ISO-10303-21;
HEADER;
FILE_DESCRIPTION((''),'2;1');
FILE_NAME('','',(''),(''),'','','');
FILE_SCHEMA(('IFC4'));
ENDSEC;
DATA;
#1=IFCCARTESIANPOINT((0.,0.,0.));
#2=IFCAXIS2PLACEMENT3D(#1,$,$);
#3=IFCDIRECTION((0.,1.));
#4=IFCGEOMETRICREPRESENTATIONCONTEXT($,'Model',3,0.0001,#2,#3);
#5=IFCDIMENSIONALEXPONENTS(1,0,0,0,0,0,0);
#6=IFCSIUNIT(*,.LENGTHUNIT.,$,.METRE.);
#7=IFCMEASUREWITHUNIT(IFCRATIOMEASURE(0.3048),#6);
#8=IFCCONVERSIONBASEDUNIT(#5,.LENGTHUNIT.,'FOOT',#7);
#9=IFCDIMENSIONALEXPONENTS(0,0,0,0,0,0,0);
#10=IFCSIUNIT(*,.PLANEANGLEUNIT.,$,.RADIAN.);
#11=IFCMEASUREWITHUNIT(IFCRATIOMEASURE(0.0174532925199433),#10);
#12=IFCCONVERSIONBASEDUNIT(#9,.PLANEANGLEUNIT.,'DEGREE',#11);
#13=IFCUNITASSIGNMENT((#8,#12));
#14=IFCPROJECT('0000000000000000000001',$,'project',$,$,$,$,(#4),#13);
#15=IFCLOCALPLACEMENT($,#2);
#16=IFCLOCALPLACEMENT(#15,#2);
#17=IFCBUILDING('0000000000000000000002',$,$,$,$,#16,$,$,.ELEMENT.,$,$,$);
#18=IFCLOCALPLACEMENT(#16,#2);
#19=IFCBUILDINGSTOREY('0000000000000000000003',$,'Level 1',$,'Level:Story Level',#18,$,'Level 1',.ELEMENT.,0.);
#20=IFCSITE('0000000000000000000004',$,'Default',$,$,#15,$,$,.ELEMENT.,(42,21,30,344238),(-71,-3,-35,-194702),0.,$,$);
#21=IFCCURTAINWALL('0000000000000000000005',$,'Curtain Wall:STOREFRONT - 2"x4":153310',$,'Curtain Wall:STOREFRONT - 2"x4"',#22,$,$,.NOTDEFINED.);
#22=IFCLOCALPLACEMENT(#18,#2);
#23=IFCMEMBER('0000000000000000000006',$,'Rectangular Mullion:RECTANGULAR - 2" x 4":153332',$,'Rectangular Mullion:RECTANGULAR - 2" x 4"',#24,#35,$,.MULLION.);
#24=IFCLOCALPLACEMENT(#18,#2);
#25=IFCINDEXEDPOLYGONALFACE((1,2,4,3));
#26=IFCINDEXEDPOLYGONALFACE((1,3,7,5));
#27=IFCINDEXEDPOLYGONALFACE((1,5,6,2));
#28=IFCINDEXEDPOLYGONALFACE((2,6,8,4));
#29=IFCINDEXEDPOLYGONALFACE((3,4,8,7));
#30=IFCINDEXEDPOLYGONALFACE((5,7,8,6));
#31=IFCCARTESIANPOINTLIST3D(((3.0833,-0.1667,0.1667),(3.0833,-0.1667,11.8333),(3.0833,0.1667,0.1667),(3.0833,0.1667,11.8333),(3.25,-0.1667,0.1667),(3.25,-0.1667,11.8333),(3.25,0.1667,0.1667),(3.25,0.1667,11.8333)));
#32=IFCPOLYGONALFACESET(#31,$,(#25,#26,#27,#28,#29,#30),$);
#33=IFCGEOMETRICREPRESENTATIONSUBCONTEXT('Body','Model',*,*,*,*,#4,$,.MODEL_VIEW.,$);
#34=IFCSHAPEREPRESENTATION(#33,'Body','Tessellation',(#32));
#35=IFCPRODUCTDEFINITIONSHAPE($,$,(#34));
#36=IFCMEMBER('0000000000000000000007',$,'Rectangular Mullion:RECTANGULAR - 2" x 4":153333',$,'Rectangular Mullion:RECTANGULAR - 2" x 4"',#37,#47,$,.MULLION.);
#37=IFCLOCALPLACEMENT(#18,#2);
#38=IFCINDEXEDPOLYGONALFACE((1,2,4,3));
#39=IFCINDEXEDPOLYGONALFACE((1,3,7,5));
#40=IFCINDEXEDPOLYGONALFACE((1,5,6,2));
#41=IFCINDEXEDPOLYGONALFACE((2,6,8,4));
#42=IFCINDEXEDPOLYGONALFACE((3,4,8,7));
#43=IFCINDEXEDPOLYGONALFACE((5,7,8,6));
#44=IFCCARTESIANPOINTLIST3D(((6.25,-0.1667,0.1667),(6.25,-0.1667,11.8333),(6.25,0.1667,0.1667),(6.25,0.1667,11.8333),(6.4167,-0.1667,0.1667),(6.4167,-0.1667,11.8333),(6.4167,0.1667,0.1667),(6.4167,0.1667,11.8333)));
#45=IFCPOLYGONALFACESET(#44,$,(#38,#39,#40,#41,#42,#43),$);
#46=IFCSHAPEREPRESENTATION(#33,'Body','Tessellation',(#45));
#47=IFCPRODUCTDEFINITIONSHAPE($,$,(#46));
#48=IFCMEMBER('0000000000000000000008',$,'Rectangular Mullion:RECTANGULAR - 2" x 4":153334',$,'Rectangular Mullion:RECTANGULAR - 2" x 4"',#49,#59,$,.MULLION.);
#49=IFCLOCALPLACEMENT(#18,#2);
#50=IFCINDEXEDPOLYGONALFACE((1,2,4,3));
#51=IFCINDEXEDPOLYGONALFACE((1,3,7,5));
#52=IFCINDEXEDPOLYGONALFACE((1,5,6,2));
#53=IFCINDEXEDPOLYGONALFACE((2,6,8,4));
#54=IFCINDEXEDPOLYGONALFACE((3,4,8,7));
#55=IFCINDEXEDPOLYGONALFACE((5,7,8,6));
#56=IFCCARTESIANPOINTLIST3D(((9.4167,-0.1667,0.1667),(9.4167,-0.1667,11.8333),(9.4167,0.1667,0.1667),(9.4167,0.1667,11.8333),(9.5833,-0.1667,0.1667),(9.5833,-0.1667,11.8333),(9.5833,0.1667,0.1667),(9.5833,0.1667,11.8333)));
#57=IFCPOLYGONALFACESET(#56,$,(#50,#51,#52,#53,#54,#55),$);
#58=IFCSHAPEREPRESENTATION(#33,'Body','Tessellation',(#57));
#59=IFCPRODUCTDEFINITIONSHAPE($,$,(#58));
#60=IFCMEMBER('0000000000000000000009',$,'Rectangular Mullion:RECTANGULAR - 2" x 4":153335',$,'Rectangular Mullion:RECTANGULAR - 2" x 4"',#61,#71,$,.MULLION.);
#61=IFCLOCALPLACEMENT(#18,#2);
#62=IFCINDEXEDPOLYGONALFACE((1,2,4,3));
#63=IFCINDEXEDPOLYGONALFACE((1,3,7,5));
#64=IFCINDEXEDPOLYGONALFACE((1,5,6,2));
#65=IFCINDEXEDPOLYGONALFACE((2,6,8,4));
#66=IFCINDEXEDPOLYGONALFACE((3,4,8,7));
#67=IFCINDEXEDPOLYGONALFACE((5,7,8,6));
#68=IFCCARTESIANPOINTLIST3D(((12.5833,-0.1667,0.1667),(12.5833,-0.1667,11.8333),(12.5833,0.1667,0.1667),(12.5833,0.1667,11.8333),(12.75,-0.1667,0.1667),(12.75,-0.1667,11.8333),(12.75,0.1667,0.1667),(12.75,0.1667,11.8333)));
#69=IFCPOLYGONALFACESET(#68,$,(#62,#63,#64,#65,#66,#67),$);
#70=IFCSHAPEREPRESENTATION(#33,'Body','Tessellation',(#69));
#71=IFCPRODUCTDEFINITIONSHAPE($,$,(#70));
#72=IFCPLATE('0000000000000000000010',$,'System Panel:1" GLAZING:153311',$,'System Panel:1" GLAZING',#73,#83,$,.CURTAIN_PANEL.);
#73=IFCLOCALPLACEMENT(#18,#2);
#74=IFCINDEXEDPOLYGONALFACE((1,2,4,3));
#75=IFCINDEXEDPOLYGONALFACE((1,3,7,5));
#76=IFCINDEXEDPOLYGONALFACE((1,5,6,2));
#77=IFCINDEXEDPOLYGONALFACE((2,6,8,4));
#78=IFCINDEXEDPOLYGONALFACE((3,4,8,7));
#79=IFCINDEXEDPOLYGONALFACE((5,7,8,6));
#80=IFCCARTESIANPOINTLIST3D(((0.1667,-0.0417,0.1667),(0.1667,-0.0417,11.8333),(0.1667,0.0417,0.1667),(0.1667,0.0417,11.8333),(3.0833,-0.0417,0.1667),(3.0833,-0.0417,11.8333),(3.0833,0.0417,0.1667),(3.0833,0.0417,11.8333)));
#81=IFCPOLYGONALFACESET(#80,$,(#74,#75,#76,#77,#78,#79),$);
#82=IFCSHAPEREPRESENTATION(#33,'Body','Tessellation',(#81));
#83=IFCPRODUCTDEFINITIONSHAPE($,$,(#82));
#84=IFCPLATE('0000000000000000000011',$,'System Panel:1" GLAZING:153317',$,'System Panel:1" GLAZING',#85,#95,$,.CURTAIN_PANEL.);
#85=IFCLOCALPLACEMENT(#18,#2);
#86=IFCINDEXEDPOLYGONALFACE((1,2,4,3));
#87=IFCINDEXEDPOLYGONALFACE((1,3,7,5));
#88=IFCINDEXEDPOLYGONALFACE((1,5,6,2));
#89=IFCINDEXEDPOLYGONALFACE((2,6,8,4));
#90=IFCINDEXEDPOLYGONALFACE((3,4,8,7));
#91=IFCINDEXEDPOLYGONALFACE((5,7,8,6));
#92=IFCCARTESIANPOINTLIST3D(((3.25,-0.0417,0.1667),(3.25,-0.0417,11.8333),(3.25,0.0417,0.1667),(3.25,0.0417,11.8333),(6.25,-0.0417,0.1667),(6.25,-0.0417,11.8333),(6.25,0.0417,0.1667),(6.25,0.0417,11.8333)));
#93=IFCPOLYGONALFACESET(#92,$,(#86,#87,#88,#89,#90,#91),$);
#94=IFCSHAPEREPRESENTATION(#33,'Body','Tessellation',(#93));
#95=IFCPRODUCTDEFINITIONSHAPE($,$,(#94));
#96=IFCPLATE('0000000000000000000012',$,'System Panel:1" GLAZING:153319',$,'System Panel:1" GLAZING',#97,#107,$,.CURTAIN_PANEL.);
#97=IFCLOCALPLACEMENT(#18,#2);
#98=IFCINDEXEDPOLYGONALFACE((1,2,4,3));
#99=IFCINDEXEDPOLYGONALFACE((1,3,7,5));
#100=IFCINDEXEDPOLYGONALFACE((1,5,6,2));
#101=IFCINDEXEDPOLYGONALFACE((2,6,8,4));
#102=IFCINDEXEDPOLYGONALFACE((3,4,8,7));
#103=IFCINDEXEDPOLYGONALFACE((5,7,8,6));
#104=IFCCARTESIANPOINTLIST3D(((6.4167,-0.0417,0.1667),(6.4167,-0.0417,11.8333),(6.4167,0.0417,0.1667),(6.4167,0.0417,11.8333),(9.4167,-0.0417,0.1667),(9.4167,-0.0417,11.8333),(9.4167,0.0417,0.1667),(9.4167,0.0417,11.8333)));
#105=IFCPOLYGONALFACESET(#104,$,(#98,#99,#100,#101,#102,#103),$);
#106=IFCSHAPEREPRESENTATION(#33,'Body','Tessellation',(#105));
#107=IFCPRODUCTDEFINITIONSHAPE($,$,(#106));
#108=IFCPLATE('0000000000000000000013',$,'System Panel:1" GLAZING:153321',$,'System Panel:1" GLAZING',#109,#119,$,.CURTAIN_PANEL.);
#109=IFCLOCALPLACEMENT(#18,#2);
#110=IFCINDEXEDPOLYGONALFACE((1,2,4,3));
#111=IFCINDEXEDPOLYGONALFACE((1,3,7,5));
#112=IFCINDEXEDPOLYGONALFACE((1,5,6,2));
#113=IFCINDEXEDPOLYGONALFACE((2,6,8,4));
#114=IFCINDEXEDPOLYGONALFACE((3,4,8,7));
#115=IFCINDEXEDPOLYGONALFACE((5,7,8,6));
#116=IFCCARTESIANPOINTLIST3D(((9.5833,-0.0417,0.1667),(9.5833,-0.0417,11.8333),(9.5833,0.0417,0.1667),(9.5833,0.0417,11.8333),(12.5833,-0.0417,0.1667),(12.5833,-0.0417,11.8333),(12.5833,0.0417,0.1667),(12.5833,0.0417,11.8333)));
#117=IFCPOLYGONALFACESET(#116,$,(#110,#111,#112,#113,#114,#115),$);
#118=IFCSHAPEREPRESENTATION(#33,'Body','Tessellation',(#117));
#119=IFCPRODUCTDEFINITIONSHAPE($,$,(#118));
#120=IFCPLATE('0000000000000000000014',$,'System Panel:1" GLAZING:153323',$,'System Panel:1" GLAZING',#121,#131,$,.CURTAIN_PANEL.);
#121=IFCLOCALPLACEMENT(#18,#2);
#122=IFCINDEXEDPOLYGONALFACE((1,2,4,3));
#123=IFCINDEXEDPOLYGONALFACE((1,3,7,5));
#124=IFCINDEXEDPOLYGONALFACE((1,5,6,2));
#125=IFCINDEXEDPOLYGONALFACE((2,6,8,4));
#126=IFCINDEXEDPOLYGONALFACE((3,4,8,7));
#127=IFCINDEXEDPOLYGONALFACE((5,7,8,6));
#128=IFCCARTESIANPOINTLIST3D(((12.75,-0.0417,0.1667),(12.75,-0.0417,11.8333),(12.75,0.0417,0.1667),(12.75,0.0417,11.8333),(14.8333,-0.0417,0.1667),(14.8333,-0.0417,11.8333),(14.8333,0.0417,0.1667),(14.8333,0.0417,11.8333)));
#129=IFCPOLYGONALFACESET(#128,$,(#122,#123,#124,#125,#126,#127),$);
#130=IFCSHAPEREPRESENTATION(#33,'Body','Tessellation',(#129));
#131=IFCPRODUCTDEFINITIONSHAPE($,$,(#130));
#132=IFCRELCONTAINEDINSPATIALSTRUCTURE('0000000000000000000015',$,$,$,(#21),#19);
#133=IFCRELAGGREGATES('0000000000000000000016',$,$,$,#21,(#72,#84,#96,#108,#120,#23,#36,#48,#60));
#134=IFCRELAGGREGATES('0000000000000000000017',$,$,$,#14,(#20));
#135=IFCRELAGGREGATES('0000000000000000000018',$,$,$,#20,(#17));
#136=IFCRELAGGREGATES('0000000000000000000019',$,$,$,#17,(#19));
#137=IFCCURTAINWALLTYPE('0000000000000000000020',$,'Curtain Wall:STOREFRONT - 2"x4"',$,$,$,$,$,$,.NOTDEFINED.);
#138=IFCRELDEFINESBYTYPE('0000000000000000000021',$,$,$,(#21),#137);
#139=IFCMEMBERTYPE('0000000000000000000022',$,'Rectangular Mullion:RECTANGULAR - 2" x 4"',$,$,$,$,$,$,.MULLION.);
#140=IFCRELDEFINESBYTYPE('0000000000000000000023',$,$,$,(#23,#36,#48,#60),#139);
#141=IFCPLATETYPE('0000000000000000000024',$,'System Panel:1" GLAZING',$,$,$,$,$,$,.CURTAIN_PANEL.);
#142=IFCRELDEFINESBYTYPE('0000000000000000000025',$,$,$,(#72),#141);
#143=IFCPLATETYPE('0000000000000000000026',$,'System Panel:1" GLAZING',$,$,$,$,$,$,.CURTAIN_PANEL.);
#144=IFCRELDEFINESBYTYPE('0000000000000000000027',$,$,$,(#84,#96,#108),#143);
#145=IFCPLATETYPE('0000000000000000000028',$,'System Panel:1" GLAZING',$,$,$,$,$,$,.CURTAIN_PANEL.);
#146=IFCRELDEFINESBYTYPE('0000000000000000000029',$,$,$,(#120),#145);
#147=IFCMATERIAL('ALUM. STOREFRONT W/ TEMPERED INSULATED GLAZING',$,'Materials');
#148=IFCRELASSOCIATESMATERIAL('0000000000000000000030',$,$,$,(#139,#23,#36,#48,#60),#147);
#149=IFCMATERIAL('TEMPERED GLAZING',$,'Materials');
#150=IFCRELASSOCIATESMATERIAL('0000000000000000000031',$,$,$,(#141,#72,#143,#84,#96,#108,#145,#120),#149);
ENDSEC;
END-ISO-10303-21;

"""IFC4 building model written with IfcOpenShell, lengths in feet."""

from ifc_helpers import new_model, entity, si_unit, converted_unit, direction, frame, origin, origin_2d_with_axis, place, context, subcontext, project, spatial, rectangle, extrude, shape, source, transform, mapped, material, material_profile, profile_set, profile_usage, type_object, type_shapes, element, aggregate, save


model = new_model("IFC4")

# Units and contexts
model_context = context("Model", 3, precision=0.0001, world=origin(), true_north=direction((0.0, 1.0)))
body_context = subcontext(model_context, "Body", "Model", "MODEL_VIEW")
footprint_context = subcontext(model_context, "FootPrint", "Model", "MODEL_VIEW")
ifc_project = project(units=[converted_unit("LENGTHUNIT", "FOOT", entity("IfcRatioMeasure", 0.3048), si_unit("LENGTHUNIT", "METRE"), dimensions=[1, 0, 0, 0, 0, 0, 0]), converted_unit("PLANEANGLEUNIT", "DEGREE", entity("IfcRatioMeasure", 0.0174532925199433), si_unit("PLANEANGLEUNIT", "RADIAN"), dimensions=[0, 0, 0, 0, 0, 0, 0])], contexts=[model_context])

# Site, building, storey
site_placement = place(None, origin())
site = spatial("IfcSite", under=ifc_project, at=site_placement, Name="Default", CompositionType="ELEMENT", RefLatitude=(42, 21, 30, 344238), RefLongitude=(-71, -3, -35, -194702), RefElevation=0.0)
building_placement = place(site_placement, origin())
building = spatial("IfcBuilding", under=site, at=building_placement, CompositionType="ELEMENT")
storey_placement = place(building_placement, origin())
storey = spatial("IfcBuildingStorey", under=building, at=storey_placement, Name="Level 1", ObjectType="Level:Story Level", LongName="Level 1", CompositionType="ELEMENT", Elevation=0.0)

# Curtain wall, members, plates
curtain_wall_type = type_object("IfcCurtainWallType", Name="Curtain Wall:STOREFRONT - 2\"x4\"", PredefinedType="NOTDEFINED")
curtain_wall_placement = place(storey_placement, origin())
curtain_wall = element("IfcCurtainWall", 1, at=curtain_wall_placement, inside=storey, type_object=curtain_wall_type, Name="Curtain Wall:STOREFRONT - 2\"x4\":153310", ObjectType="Curtain Wall:STOREFRONT - 2\"x4\"", PredefinedType="NOTDEFINED")
ifc_material_1 = material(Name="ALUM. STOREFRONT W/ TEMPERED INSULATED GLAZING", Category="Materials")
ifc_material_profile = material_profile(ifc_material_1, rectangle(XDim=0.3333, YDim=0.1667, at=origin_2d_with_axis()), Name="RECTANGULAR - 2\" x 4\"")
ifc_profile_set = profile_set([ifc_material_profile], Name="RECTANGULAR - 2\" x 4\"")
ifc_profile_usage_1 = profile_usage(ifc_profile_set)
member_type_1 = type_object("IfcMemberType", Name="Rectangular Mullion:RECTANGULAR - 2\" x 4\"", PredefinedType="MULLION", material=ifc_profile_set)
shared_shape_1 = source(origin(), body_context, "Body", "SweptSolid", [
    extrude(rectangle(XDim=0.3333, YDim=0.1667, at=origin_2d_with_axis()), frame((0.0, 0.0, -11.6667), z_axis=(0.0, 0.0, 1.0), x_axis=(0.0, -1.0, 0.0)), (0.0, 0.0, 1.0), 11.6667),
])
type_shapes(member_type_1, [shared_shape_1])
member_1_placement = place(storey_placement, frame((3.1667, 0.0, 0.1667), z_axis=(0.0, 0.0, -1.0), x_axis=(1.0, 0.0, 0.0)))
member_1 = element("IfcMember", 2, at=member_1_placement, type_object=member_type_1, material=ifc_profile_usage_1, Name="Rectangular Mullion:RECTANGULAR - 2\" x 4\":153332", ObjectType="Rectangular Mullion:RECTANGULAR - 2\" x 4\"", PredefinedType="MULLION", context=body_context, shape_type="MappedRepresentation", body=[
    mapped(shared_shape_1, transform((0.0, 0.0, 0.0), scale=1.0)),
])
ifc_profile_usage_2 = profile_usage(ifc_profile_set)
member_2_placement = place(storey_placement, frame((6.3333, 0.0, 0.1667), z_axis=(0.0, 0.0, -1.0), x_axis=(1.0, 0.0, 0.0)))
member_2 = element("IfcMember", 3, at=member_2_placement, type_object=member_type_1, material=ifc_profile_usage_2, Name="Rectangular Mullion:RECTANGULAR - 2\" x 4\":153333", ObjectType="Rectangular Mullion:RECTANGULAR - 2\" x 4\"", PredefinedType="MULLION", context=body_context, shape_type="MappedRepresentation", body=[
    mapped(shared_shape_1, transform((0.0, 0.0, 0.0), scale=1.0)),
])
ifc_profile_usage_3 = profile_usage(ifc_profile_set)
member_3_placement = place(storey_placement, frame((9.5, 0.0, 0.1667), z_axis=(0.0, 0.0, -1.0), x_axis=(1.0, 0.0, 0.0)))
member_3 = element("IfcMember", 4, at=member_3_placement, type_object=member_type_1, material=ifc_profile_usage_3, Name="Rectangular Mullion:RECTANGULAR - 2\" x 4\":153334", ObjectType="Rectangular Mullion:RECTANGULAR - 2\" x 4\"", PredefinedType="MULLION", context=body_context, shape_type="MappedRepresentation", body=[
    mapped(shared_shape_1, transform((0.0, 0.0, 0.0), scale=1.0)),
])
ifc_profile_usage_4 = profile_usage(ifc_profile_set)
member_4_placement = place(storey_placement, frame((12.6667, 0.0, 0.1667), z_axis=(0.0, 0.0, -1.0), x_axis=(1.0, 0.0, 0.0)))
member_4 = element("IfcMember", 5, at=member_4_placement, type_object=member_type_1, material=ifc_profile_usage_4, Name="Rectangular Mullion:RECTANGULAR - 2\" x 4\":153335", ObjectType="Rectangular Mullion:RECTANGULAR - 2\" x 4\"", PredefinedType="MULLION", context=body_context, shape_type="MappedRepresentation", body=[
    mapped(shared_shape_1, transform((0.0, 0.0, 0.0), scale=1.0)),
])
ifc_material_2 = material(Name="TEMPERED GLAZING", Category="Materials")
plate_type_1 = type_object("IfcPlateType", Name="System Panel:1\" GLAZING", PredefinedType="CURTAIN_PANEL", material=ifc_material_2)
shared_shape_2 = source(origin(), body_context, "Body", "SweptSolid", [
    extrude(rectangle(XDim=0.0833, YDim=2.9167, at=origin_2d_with_axis()), frame((0.0, 0.0, 0.0), z_axis=(0.0, 0.0, 1.0), x_axis=(0.0, 1.0, 0.0)), (0.0, 0.0, 1.0), 11.6667),
])
cartesian_point_1 = entity("IfcCartesianPoint", [1.4583, -0.0417])
shared_shape_3 = source(origin(), footprint_context, "FootPrint", "Curve2D", [
    entity("IfcPolyline", [cartesian_point_1, entity("IfcCartesianPoint", [1.4583, 0.0417]), entity("IfcCartesianPoint", [-1.4583, 0.0417]), entity("IfcCartesianPoint", [-1.4583, -0.0417]), cartesian_point_1]),
])
type_shapes(plate_type_1, [shared_shape_2, shared_shape_3])
plate_1_placement = place(curtain_wall_placement, frame((1.625, 0.0, 0.1667)))
plate_1 = element("IfcPlate", 6, at=plate_1_placement, type_object=plate_type_1, material=ifc_material_2, Name="System Panel:1\" GLAZING:153311", ObjectType="System Panel:1\" GLAZING", PredefinedType="CURTAIN_PANEL", shapes=[
    shape(body_context, "Body", "MappedRepresentation", [mapped(shared_shape_2, transform((0.0, 0.0, 0.0), scale=1.0))]),
    shape(body_context, "Body", "MappedRepresentation", [mapped(shared_shape_3, transform((0.0, 0.0, 0.0), scale=1.0))]),
])
plate_type_2 = type_object("IfcPlateType", Name="System Panel:1\" GLAZING", PredefinedType="CURTAIN_PANEL", material=ifc_material_2)
shared_shape_4 = source(origin(), body_context, "Body", "SweptSolid", [
    extrude(rectangle(XDim=0.0833, YDim=3.0, at=origin_2d_with_axis()), frame((0.0, 0.0, 0.0), z_axis=(0.0, 0.0, 1.0), x_axis=(0.0, 1.0, 0.0)), (0.0, 0.0, 1.0), 11.6667),
])
cartesian_point_2 = entity("IfcCartesianPoint", [1.5, -0.0417])
shared_shape_5 = source(origin(), footprint_context, "FootPrint", "Curve2D", [
    entity("IfcPolyline", [cartesian_point_2, entity("IfcCartesianPoint", [1.5, 0.0417]), entity("IfcCartesianPoint", [-1.5, 0.0417]), entity("IfcCartesianPoint", [-1.5, -0.0417]), cartesian_point_2]),
])
type_shapes(plate_type_2, [shared_shape_4, shared_shape_5])
plate_2_placement = place(curtain_wall_placement, frame((4.75, 0.0, 0.1667)))
plate_2 = element("IfcPlate", 7, at=plate_2_placement, type_object=plate_type_2, material=ifc_material_2, Name="System Panel:1\" GLAZING:153317", ObjectType="System Panel:1\" GLAZING", PredefinedType="CURTAIN_PANEL", shapes=[
    shape(body_context, "Body", "MappedRepresentation", [mapped(shared_shape_4, transform((0.0, 0.0, 0.0), scale=1.0))]),
    shape(body_context, "Body", "MappedRepresentation", [mapped(shared_shape_5, transform((0.0, 0.0, 0.0), scale=1.0))]),
])
plate_3_placement = place(curtain_wall_placement, frame((7.9167, 0.0, 0.1667)))
plate_3 = element("IfcPlate", 8, at=plate_3_placement, type_object=plate_type_2, material=ifc_material_2, Name="System Panel:1\" GLAZING:153319", ObjectType="System Panel:1\" GLAZING", PredefinedType="CURTAIN_PANEL", shapes=[
    shape(body_context, "Body", "MappedRepresentation", [mapped(shared_shape_4, transform((0.0, 0.0, 0.0), scale=1.0))]),
    shape(body_context, "Body", "MappedRepresentation", [mapped(shared_shape_5, transform((0.0, 0.0, 0.0), scale=1.0))]),
])
plate_4_placement = place(curtain_wall_placement, frame((11.0833, 0.0, 0.1667)))
plate_4 = element("IfcPlate", 9, at=plate_4_placement, type_object=plate_type_2, material=ifc_material_2, Name="System Panel:1\" GLAZING:153321", ObjectType="System Panel:1\" GLAZING", PredefinedType="CURTAIN_PANEL", shapes=[
    shape(body_context, "Body", "MappedRepresentation", [mapped(shared_shape_4, transform((0.0, 0.0, 0.0), scale=1.0))]),
    shape(body_context, "Body", "MappedRepresentation", [mapped(shared_shape_5, transform((0.0, 0.0, 0.0), scale=1.0))]),
])
plate_type_3 = type_object("IfcPlateType", Name="System Panel:1\" GLAZING", PredefinedType="CURTAIN_PANEL", material=ifc_material_2)
shared_shape_6 = source(origin(), body_context, "Body", "SweptSolid", [
    extrude(rectangle(XDim=0.0833, YDim=2.0833, at=origin_2d_with_axis()), frame((0.0, 0.0, 0.0), z_axis=(0.0, 0.0, 1.0), x_axis=(0.0, 1.0, 0.0)), (0.0, 0.0, 1.0), 11.6667),
])
cartesian_point_3 = entity("IfcCartesianPoint", [1.0417, -0.0417])
shared_shape_7 = source(origin(), footprint_context, "FootPrint", "Curve2D", [
    entity("IfcPolyline", [cartesian_point_3, entity("IfcCartesianPoint", [1.0417, 0.0417]), entity("IfcCartesianPoint", [-1.0417, 0.0417]), entity("IfcCartesianPoint", [-1.0417, -0.0417]), cartesian_point_3]),
])
type_shapes(plate_type_3, [shared_shape_6, shared_shape_7])
plate_5_placement = place(curtain_wall_placement, frame((13.7917, 0.0, 0.1667)))
plate_5 = element("IfcPlate", 10, at=plate_5_placement, type_object=plate_type_3, material=ifc_material_2, Name="System Panel:1\" GLAZING:153323", ObjectType="System Panel:1\" GLAZING", PredefinedType="CURTAIN_PANEL", shapes=[
    shape(body_context, "Body", "MappedRepresentation", [mapped(shared_shape_6, transform((0.0, 0.0, 0.0), scale=1.0))]),
    shape(body_context, "Body", "MappedRepresentation", [mapped(shared_shape_7, transform((0.0, 0.0, 0.0), scale=1.0))]),
])
aggregate(curtain_wall, [plate_1, plate_2, plate_3, plate_4, plate_5, member_1, member_2, member_3, member_4])

save(model, "model.ifc")
